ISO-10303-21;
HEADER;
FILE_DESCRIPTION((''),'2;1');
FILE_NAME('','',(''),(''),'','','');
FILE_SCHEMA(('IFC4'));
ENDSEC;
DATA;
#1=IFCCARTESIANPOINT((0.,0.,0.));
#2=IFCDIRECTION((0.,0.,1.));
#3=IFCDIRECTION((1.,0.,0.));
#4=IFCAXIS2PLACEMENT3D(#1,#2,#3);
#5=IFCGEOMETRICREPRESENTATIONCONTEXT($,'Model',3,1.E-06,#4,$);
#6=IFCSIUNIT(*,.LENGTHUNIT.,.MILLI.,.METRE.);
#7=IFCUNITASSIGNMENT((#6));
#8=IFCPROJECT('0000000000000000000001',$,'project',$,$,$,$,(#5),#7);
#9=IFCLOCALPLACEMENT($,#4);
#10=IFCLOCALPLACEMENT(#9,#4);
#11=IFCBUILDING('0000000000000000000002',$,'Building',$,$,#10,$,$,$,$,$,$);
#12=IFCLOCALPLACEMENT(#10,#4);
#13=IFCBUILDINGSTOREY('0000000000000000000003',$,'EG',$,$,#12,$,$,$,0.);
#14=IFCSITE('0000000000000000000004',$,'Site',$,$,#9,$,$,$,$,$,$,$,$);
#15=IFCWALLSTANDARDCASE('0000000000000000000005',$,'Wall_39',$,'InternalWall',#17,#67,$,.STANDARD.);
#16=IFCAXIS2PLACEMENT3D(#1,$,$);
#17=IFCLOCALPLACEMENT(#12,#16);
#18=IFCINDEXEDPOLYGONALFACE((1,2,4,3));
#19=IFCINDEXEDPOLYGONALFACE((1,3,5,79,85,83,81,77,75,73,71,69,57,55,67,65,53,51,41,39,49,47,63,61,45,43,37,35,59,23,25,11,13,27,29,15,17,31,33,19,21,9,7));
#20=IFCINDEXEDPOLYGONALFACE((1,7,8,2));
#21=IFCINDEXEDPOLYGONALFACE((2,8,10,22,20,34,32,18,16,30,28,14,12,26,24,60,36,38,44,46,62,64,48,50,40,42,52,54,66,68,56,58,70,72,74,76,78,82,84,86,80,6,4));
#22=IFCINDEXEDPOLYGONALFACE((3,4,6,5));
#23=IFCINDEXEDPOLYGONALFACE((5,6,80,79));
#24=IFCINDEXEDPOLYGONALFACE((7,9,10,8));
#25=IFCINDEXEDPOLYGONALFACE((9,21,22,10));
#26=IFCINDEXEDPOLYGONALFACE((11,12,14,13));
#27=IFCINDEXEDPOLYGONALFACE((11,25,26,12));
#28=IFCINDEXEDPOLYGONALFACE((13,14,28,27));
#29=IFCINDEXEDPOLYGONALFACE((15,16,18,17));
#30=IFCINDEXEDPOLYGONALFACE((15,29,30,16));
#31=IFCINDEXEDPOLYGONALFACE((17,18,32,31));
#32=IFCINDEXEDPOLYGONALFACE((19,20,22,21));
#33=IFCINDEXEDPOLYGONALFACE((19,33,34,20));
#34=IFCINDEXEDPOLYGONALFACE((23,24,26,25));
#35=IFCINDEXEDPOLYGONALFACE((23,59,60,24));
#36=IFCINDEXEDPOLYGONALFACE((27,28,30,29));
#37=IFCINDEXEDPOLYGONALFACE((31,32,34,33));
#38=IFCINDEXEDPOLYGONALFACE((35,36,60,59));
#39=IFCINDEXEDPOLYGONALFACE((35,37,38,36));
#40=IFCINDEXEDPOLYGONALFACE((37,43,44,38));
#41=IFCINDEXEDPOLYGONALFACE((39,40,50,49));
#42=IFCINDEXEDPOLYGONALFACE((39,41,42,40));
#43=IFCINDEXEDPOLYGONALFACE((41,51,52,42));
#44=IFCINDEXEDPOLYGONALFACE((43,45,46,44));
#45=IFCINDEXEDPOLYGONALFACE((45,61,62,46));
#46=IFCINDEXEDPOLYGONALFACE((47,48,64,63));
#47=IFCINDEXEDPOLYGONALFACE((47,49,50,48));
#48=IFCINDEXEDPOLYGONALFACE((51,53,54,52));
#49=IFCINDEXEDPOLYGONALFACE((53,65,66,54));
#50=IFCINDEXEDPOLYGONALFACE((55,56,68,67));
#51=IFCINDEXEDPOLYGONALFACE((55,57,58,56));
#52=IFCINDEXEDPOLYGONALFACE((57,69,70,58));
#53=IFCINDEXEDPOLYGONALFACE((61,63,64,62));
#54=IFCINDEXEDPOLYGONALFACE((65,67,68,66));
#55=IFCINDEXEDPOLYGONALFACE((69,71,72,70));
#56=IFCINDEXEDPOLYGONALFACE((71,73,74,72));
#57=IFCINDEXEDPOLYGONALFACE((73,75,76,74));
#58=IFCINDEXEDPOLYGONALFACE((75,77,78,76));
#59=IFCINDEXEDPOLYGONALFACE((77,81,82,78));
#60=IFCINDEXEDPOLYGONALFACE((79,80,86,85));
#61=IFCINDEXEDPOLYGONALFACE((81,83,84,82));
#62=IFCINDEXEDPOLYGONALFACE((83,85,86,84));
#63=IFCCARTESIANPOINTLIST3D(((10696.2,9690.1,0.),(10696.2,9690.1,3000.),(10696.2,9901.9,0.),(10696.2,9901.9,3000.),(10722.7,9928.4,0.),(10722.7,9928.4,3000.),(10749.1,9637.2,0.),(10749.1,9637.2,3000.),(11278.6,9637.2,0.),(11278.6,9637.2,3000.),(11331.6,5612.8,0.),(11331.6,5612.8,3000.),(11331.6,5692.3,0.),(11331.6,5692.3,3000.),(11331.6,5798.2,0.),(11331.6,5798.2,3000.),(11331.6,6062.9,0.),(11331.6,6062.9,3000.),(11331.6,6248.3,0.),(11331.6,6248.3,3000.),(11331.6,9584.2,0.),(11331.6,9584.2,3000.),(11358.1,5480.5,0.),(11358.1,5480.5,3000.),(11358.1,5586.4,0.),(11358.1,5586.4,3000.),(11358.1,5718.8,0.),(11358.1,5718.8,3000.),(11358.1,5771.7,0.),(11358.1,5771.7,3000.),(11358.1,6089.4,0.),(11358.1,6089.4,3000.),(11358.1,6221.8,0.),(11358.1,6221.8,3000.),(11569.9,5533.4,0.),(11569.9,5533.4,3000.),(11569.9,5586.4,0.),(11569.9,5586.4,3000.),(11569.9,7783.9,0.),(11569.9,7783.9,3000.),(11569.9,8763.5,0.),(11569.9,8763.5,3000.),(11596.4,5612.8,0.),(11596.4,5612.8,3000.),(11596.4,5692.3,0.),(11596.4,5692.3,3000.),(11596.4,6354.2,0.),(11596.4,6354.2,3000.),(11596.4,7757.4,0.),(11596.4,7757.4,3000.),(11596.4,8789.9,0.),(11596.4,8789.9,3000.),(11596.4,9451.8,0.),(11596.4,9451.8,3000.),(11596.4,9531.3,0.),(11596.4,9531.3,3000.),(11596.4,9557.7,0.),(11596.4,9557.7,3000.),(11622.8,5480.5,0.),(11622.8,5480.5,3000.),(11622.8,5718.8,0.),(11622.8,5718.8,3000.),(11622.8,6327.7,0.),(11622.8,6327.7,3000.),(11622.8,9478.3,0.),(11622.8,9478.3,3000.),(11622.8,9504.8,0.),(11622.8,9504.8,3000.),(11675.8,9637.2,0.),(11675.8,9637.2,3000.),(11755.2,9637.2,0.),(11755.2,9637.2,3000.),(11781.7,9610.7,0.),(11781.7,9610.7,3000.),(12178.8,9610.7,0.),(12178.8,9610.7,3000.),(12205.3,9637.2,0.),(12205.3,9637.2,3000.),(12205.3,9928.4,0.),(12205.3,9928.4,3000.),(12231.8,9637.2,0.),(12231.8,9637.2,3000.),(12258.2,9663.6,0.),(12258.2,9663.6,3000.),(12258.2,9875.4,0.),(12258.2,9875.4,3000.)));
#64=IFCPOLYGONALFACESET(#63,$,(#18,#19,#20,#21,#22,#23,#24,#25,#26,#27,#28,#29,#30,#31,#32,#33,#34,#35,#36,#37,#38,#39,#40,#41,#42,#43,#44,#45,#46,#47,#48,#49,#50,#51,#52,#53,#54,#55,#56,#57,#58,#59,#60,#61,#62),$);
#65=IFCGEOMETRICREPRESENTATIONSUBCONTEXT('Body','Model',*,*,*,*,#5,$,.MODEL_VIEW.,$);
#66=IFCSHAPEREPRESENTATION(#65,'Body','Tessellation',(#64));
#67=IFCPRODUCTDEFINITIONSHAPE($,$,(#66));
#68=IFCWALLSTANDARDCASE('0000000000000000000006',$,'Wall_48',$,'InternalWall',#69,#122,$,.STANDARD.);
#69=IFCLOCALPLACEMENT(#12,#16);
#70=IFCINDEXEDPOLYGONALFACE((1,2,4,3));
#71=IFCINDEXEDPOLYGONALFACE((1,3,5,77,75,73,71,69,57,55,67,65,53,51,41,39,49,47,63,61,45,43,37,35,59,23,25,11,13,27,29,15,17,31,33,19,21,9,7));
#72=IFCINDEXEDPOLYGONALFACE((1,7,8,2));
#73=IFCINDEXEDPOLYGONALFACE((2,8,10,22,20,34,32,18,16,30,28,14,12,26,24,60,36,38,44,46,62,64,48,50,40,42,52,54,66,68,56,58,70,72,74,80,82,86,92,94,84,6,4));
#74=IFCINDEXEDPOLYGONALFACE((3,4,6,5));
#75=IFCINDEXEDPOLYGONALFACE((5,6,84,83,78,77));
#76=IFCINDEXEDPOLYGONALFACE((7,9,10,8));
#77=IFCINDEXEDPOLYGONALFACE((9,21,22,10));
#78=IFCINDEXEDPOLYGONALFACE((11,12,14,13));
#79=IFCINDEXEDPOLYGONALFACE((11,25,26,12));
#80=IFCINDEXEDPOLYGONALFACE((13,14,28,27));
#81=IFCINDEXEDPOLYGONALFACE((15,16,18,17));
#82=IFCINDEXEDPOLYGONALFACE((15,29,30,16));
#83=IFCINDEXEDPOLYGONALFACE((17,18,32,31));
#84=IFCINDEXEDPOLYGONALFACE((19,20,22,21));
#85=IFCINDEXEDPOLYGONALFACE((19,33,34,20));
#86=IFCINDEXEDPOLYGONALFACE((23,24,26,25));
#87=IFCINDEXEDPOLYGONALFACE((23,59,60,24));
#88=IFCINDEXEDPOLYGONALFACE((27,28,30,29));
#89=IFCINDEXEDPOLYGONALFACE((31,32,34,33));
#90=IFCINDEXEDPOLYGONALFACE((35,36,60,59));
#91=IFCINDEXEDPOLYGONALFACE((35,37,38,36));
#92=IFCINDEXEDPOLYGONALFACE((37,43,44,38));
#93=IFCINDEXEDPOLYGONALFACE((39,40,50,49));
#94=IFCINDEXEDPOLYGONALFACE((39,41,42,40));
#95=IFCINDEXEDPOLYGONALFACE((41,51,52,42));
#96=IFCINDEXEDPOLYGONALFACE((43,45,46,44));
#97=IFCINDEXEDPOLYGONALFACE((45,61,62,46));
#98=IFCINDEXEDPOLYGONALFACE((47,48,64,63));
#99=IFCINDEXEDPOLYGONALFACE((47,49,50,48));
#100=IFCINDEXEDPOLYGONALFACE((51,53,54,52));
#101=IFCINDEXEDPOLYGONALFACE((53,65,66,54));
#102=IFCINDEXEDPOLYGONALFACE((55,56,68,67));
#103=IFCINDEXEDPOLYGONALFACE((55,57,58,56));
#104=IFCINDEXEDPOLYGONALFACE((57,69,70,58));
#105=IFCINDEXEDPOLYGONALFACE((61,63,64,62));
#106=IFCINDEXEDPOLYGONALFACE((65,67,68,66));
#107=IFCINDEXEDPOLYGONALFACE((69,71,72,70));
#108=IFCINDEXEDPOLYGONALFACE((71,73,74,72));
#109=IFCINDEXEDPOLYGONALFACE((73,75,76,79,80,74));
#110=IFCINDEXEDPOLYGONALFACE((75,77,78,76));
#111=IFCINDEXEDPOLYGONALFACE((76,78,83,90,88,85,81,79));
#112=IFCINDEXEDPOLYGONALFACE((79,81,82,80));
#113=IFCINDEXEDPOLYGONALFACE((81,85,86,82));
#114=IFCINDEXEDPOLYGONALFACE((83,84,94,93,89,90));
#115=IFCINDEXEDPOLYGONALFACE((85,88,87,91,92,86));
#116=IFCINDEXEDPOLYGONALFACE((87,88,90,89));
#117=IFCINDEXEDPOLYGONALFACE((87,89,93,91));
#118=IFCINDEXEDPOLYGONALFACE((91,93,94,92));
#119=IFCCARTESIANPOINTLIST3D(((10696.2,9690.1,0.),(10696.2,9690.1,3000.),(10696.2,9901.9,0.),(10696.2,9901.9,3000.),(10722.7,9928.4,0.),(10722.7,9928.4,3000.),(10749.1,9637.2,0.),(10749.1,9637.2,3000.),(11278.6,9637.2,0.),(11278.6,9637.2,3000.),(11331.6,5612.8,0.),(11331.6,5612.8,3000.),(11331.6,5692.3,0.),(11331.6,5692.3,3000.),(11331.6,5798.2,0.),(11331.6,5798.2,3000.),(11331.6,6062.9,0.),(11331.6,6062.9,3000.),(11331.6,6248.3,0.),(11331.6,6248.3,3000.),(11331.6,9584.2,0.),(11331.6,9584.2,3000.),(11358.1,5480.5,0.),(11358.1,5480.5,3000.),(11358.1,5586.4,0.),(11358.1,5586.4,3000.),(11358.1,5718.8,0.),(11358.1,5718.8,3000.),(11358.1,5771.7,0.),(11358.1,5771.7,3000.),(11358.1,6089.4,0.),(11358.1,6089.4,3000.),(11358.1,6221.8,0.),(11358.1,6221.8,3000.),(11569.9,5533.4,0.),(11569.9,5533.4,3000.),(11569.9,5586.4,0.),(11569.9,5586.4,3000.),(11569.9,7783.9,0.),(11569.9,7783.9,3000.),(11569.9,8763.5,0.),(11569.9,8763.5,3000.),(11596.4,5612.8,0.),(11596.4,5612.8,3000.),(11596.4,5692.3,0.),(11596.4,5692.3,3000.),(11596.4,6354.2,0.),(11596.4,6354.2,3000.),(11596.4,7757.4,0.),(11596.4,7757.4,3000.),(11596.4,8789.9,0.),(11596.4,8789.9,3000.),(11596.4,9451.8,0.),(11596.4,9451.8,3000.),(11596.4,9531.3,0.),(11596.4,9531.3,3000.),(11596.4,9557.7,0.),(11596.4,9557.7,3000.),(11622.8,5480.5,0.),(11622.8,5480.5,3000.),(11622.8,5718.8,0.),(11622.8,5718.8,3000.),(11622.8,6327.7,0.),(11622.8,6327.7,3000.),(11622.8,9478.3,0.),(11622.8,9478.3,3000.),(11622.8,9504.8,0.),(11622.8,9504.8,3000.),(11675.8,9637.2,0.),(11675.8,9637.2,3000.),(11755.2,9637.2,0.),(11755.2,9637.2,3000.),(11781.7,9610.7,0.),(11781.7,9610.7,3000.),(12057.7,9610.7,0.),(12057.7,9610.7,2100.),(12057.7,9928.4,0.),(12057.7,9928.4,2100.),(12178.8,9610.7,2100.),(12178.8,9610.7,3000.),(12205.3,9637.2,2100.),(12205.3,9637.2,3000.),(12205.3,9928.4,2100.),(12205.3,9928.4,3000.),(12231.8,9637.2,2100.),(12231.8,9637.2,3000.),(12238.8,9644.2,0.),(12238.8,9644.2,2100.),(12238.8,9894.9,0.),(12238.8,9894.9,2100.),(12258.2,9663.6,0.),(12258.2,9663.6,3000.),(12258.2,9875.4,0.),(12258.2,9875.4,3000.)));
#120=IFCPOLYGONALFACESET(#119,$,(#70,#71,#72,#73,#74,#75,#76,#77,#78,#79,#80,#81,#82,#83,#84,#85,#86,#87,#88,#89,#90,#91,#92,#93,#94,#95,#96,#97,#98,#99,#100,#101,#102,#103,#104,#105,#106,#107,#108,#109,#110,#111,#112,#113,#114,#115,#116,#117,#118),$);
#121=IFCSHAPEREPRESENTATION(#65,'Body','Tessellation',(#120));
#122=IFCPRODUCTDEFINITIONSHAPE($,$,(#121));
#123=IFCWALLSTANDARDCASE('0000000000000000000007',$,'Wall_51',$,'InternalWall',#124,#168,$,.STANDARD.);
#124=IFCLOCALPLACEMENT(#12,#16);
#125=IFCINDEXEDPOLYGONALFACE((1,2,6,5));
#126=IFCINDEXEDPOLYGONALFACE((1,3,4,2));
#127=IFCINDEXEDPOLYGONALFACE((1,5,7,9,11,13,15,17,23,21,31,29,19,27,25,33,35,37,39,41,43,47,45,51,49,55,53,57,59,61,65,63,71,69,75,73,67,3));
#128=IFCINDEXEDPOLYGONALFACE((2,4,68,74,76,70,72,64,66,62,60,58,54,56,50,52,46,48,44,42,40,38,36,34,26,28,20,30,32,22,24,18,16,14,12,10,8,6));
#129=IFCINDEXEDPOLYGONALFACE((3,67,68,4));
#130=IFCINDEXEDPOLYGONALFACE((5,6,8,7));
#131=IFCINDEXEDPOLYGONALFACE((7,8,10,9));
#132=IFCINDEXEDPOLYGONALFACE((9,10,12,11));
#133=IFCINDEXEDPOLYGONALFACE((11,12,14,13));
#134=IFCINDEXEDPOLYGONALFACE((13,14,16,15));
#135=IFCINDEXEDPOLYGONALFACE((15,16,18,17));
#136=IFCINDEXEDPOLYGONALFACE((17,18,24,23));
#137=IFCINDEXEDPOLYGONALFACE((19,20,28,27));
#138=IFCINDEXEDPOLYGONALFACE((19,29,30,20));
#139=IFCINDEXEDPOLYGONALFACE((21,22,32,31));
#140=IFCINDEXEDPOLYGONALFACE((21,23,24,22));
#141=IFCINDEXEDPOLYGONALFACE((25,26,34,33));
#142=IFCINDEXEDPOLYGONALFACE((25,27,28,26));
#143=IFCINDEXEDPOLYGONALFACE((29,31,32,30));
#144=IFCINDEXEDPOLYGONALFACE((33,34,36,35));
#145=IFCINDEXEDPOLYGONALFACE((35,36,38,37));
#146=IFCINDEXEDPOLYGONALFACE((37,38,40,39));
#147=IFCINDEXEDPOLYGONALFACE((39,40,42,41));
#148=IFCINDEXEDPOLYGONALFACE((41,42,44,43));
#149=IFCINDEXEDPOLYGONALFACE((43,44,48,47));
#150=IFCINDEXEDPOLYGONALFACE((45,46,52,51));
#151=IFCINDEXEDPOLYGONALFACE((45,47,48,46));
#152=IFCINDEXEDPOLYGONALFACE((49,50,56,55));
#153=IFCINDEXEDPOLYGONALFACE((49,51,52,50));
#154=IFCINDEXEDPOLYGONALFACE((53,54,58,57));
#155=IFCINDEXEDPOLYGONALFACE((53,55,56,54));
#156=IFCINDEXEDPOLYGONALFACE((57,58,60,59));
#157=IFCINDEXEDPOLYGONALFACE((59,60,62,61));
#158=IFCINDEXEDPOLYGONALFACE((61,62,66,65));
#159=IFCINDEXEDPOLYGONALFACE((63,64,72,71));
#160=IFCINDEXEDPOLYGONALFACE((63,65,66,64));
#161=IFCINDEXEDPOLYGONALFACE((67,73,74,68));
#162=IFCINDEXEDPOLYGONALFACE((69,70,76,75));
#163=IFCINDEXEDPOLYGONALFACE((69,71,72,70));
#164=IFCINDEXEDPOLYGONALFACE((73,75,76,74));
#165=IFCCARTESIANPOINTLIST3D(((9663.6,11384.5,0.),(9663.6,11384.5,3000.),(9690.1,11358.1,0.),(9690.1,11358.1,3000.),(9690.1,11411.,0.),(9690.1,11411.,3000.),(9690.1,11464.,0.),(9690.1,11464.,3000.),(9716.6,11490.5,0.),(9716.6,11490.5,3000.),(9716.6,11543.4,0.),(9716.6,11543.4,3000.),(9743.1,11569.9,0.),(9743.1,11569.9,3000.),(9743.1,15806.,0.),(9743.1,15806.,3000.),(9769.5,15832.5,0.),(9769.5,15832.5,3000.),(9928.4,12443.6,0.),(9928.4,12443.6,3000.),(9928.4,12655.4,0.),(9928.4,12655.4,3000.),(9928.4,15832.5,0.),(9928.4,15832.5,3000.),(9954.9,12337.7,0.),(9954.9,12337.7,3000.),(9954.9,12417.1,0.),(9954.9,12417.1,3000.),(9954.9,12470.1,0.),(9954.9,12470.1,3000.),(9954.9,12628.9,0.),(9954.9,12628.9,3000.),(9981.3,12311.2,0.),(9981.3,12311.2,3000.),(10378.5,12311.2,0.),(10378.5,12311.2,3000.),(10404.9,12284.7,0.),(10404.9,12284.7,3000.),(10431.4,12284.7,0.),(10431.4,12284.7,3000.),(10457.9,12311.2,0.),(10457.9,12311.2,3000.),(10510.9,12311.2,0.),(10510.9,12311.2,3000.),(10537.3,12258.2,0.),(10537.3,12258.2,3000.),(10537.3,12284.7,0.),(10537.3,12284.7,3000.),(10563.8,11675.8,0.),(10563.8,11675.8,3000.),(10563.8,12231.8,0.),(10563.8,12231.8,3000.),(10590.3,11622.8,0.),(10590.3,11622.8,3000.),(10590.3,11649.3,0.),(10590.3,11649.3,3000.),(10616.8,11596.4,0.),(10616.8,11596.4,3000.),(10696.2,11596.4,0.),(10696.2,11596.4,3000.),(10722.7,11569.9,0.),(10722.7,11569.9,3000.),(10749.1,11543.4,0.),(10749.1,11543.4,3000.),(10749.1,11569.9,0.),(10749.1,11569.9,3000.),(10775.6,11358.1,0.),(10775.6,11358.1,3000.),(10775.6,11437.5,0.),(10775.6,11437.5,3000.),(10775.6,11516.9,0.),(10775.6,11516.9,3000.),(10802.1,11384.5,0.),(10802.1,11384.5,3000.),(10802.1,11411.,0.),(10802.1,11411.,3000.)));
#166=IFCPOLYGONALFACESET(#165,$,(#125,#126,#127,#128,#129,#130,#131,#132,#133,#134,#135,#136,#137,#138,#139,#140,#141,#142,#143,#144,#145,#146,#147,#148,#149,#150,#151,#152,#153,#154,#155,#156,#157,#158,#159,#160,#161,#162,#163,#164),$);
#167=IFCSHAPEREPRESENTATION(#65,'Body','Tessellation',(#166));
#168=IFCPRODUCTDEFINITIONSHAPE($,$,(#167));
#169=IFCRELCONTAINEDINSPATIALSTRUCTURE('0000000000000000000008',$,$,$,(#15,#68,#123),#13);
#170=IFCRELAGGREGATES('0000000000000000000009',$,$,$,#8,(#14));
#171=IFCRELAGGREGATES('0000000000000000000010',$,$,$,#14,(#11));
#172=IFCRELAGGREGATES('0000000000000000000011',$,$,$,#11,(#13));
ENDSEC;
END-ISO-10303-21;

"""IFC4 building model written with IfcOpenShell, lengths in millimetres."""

from ifc_helpers import new_model, si_unit, frame, origin_with_axes, place, context, subcontext, project, spatial, polyline, rectangle, outline, extrude, element, save


model = new_model("IFC4")

# Units and contexts
model_context = context("Model", 3, precision=1e-06, world=origin_with_axes())
body_context = subcontext(model_context, "Body", "Model", "MODEL_VIEW")
ifc_project = project(units=[si_unit("LENGTHUNIT", "METRE", prefix="MILLI")], contexts=[model_context])

# Site, building, storey
site_placement = place(None, origin_with_axes())
site = spatial("IfcSite", under=ifc_project, at=site_placement, Name="Site")
building_placement = place(site_placement, origin_with_axes())
building = spatial("IfcBuilding", under=site, at=building_placement, Name="Building")
storey_placement = place(building_placement, origin_with_axes())
storey = spatial("IfcBuildingStorey", under=building, at=storey_placement, Name="EG", Elevation=0.0)

# Wall
wall_1_placement = place(storey_placement, origin_with_axes())
element("IfcWallStandardCase", 1, at=wall_1_placement, inside=storey, Name="Wall_39", ObjectType="InternalWall", PredefinedType="STANDARD", context=body_context, shape_type="SweptSolid", body=[
    extrude(outline(polyline([(11358.1, 5480.5, 0.0), (11358.1, 5586.4, 0.0), (11331.6, 5612.8, 0.0), (11331.6, 5692.3, 0.0), (11358.1, 5718.8, 0.0), (11358.1, 5771.7, 0.0), (11331.6, 5798.2, 0.0), (11331.6, 6062.9, 0.0), (11358.1, 6089.4, 0.0), (11358.1, 6221.8, 0.0), (11331.6, 6248.3, 0.0), (11331.6, 9584.2, 0.0), (11278.6, 9637.2, 0.0), (10749.1, 9637.2, 0.0), (10696.2, 9690.1, 0.0), (10696.2, 9901.9, 0.0), (10722.7, 9928.4, 0.0), (12205.3, 9928.4, 0.0), (12258.2, 9875.4, 0.0), (12258.2, 9663.6, 0.0), (12231.8, 9637.2, 0.0), (12205.3, 9637.2, 0.0), (12178.8, 9610.7, 0.0), (11781.7, 9610.7, 0.0), (11755.2, 9637.2, 0.0), (11675.8, 9637.2, 0.0), (11596.4, 9557.7, 0.0), (11596.4, 9531.3, 0.0), (11622.8, 9504.8, 0.0), (11622.8, 9478.3, 0.0), (11596.4, 9451.8, 0.0), (11596.4, 8789.9, 0.0), (11569.9, 8763.5, 0.0), (11569.9, 7783.9, 0.0), (11596.4, 7757.4, 0.0), (11596.4, 6354.2, 0.0), (11622.8, 6327.7, 0.0), (11622.8, 5718.8, 0.0), (11596.4, 5692.3, 0.0), (11596.4, 5612.8, 0.0), (11569.9, 5586.4, 0.0), (11569.9, 5533.4, 0.0), (11622.8, 5480.5, 0.0), (11755.2, 5480.5, 0.0), (11358.1, 5480.5, 0.0)])), origin_with_axes(), (0.0, 0.0, 1.0), 3000.0),
])

# Wall, opening
wall_2_placement = place(storey_placement, origin_with_axes())
wall_2 = element("IfcWallStandardCase", 2, at=wall_2_placement, inside=storey, Name="Wall_48", ObjectType="InternalWall", PredefinedType="STANDARD", context=body_context, shape_type="SweptSolid", body=[
    extrude(outline(polyline([(11358.1, 5480.5, 0.0), (11358.1, 5586.4, 0.0), (11331.6, 5612.8, 0.0), (11331.6, 5692.3, 0.0), (11358.1, 5718.8, 0.0), (11358.1, 5771.7, 0.0), (11331.6, 5798.2, 0.0), (11331.6, 6062.9, 0.0), (11358.1, 6089.4, 0.0), (11358.1, 6221.8, 0.0), (11331.6, 6248.3, 0.0), (11331.6, 9584.2, 0.0), (11278.6, 9637.2, 0.0), (10749.1, 9637.2, 0.0), (10696.2, 9690.1, 0.0), (10696.2, 9901.9, 0.0), (10722.7, 9928.4, 0.0), (12205.3, 9928.4, 0.0), (12258.2, 9875.4, 0.0), (12258.2, 9663.6, 0.0), (12231.8, 9637.2, 0.0), (12205.3, 9637.2, 0.0), (12178.8, 9610.7, 0.0), (11781.7, 9610.7, 0.0), (11755.2, 9637.2, 0.0), (11675.8, 9637.2, 0.0), (11596.4, 9557.7, 0.0), (11596.4, 9531.3, 0.0), (11622.8, 9504.8, 0.0), (11622.8, 9478.3, 0.0), (11596.4, 9451.8, 0.0), (11596.4, 8789.9, 0.0), (11569.9, 8763.5, 0.0), (11569.9, 7783.9, 0.0), (11596.4, 7757.4, 0.0), (11596.4, 6354.2, 0.0), (11622.8, 6327.7, 0.0), (11622.8, 5718.8, 0.0), (11596.4, 5692.3, 0.0), (11596.4, 5612.8, 0.0), (11569.9, 5586.4, 0.0), (11569.9, 5533.4, 0.0), (11622.8, 5480.5, 0.0), (11755.2, 5480.5, 0.0), (11358.1, 5480.5, 0.0)])), origin_with_axes(), (0.0, 0.0, 1.0), 3000.0),
])
opening_1_placement = place(wall_2_placement, origin_with_axes())
element("IfcOpeningElement", 3, at=opening_1_placement, inside=storey, cuts=wall_2, context=body_context, shape_type="SweptSolid", body=[
    extrude(rectangle(XDim=1319.5, YDim=181.1), frame((12148.2, 9739.4, 0.0), z_axis=(0.0, 0.0, 1.0), x_axis=(0.0, 1.0, 0.0)), (0.0, 0.0, 1.0), 2100.0),
])

# Wall
for number, where, z_axis, x_axis, name in (
    (4, (0.0, 0.0, 0.0), (0.0, 0.0, 1.0), (1.0, 0.0, 0.0), "Wall_51"),
):
    element("IfcWallStandardCase", number, at=place(storey_placement, frame(where, z_axis=z_axis, x_axis=x_axis)), inside=storey, Name=name, ObjectType="InternalWall", PredefinedType="STANDARD", context=body_context, shape_type="SweptSolid", body=[
        extrude(outline(polyline([(9690.1, 11358.1, 0.0), (9663.6, 11384.5, 0.0), (9690.1, 11411.0, 0.0), (9690.1, 11464.0, 0.0), (9716.6, 11490.5, 0.0), (9716.6, 11543.4, 0.0), (9743.1, 11569.9, 0.0), (9743.1, 15806.0, 0.0), (9769.5, 15832.5, 0.0), (9928.4, 15832.5, 0.0), (9928.4, 12655.4, 0.0), (9954.9, 12628.9, 0.0), (9954.9, 12470.1, 0.0), (9928.4, 12443.6, 0.0), (9954.9, 12417.1, 0.0), (9954.9, 12337.7, 0.0), (9981.3, 12311.2, 0.0), (10378.5, 12311.2, 0.0), (10404.9, 12284.7, 0.0), (10431.4, 12284.7, 0.0), (10457.9, 12311.2, 0.0), (10510.9, 12311.2, 0.0), (10537.3, 12284.7, 0.0), (10537.3, 12258.2, 0.0), (10563.8, 12231.8, 0.0), (10563.8, 11675.8, 0.0), (10590.3, 11649.3, 0.0), (10590.3, 11622.8, 0.0), (10616.8, 11596.4, 0.0), (10696.2, 11596.4, 0.0), (10722.7, 11569.9, 0.0), (10749.1, 11569.9, 0.0), (10749.1, 11543.4, 0.0), (10775.6, 11516.9, 0.0), (10775.6, 11437.5, 0.0), (10802.1, 11411.0, 0.0), (10802.1, 11384.5, 0.0), (10775.6, 11358.1, 0.0), (9690.1, 11358.1, 0.0)])), origin_with_axes(), (0.0, 0.0, 1.0), 3000.0),
    ])

save(model, "model.ifc")
